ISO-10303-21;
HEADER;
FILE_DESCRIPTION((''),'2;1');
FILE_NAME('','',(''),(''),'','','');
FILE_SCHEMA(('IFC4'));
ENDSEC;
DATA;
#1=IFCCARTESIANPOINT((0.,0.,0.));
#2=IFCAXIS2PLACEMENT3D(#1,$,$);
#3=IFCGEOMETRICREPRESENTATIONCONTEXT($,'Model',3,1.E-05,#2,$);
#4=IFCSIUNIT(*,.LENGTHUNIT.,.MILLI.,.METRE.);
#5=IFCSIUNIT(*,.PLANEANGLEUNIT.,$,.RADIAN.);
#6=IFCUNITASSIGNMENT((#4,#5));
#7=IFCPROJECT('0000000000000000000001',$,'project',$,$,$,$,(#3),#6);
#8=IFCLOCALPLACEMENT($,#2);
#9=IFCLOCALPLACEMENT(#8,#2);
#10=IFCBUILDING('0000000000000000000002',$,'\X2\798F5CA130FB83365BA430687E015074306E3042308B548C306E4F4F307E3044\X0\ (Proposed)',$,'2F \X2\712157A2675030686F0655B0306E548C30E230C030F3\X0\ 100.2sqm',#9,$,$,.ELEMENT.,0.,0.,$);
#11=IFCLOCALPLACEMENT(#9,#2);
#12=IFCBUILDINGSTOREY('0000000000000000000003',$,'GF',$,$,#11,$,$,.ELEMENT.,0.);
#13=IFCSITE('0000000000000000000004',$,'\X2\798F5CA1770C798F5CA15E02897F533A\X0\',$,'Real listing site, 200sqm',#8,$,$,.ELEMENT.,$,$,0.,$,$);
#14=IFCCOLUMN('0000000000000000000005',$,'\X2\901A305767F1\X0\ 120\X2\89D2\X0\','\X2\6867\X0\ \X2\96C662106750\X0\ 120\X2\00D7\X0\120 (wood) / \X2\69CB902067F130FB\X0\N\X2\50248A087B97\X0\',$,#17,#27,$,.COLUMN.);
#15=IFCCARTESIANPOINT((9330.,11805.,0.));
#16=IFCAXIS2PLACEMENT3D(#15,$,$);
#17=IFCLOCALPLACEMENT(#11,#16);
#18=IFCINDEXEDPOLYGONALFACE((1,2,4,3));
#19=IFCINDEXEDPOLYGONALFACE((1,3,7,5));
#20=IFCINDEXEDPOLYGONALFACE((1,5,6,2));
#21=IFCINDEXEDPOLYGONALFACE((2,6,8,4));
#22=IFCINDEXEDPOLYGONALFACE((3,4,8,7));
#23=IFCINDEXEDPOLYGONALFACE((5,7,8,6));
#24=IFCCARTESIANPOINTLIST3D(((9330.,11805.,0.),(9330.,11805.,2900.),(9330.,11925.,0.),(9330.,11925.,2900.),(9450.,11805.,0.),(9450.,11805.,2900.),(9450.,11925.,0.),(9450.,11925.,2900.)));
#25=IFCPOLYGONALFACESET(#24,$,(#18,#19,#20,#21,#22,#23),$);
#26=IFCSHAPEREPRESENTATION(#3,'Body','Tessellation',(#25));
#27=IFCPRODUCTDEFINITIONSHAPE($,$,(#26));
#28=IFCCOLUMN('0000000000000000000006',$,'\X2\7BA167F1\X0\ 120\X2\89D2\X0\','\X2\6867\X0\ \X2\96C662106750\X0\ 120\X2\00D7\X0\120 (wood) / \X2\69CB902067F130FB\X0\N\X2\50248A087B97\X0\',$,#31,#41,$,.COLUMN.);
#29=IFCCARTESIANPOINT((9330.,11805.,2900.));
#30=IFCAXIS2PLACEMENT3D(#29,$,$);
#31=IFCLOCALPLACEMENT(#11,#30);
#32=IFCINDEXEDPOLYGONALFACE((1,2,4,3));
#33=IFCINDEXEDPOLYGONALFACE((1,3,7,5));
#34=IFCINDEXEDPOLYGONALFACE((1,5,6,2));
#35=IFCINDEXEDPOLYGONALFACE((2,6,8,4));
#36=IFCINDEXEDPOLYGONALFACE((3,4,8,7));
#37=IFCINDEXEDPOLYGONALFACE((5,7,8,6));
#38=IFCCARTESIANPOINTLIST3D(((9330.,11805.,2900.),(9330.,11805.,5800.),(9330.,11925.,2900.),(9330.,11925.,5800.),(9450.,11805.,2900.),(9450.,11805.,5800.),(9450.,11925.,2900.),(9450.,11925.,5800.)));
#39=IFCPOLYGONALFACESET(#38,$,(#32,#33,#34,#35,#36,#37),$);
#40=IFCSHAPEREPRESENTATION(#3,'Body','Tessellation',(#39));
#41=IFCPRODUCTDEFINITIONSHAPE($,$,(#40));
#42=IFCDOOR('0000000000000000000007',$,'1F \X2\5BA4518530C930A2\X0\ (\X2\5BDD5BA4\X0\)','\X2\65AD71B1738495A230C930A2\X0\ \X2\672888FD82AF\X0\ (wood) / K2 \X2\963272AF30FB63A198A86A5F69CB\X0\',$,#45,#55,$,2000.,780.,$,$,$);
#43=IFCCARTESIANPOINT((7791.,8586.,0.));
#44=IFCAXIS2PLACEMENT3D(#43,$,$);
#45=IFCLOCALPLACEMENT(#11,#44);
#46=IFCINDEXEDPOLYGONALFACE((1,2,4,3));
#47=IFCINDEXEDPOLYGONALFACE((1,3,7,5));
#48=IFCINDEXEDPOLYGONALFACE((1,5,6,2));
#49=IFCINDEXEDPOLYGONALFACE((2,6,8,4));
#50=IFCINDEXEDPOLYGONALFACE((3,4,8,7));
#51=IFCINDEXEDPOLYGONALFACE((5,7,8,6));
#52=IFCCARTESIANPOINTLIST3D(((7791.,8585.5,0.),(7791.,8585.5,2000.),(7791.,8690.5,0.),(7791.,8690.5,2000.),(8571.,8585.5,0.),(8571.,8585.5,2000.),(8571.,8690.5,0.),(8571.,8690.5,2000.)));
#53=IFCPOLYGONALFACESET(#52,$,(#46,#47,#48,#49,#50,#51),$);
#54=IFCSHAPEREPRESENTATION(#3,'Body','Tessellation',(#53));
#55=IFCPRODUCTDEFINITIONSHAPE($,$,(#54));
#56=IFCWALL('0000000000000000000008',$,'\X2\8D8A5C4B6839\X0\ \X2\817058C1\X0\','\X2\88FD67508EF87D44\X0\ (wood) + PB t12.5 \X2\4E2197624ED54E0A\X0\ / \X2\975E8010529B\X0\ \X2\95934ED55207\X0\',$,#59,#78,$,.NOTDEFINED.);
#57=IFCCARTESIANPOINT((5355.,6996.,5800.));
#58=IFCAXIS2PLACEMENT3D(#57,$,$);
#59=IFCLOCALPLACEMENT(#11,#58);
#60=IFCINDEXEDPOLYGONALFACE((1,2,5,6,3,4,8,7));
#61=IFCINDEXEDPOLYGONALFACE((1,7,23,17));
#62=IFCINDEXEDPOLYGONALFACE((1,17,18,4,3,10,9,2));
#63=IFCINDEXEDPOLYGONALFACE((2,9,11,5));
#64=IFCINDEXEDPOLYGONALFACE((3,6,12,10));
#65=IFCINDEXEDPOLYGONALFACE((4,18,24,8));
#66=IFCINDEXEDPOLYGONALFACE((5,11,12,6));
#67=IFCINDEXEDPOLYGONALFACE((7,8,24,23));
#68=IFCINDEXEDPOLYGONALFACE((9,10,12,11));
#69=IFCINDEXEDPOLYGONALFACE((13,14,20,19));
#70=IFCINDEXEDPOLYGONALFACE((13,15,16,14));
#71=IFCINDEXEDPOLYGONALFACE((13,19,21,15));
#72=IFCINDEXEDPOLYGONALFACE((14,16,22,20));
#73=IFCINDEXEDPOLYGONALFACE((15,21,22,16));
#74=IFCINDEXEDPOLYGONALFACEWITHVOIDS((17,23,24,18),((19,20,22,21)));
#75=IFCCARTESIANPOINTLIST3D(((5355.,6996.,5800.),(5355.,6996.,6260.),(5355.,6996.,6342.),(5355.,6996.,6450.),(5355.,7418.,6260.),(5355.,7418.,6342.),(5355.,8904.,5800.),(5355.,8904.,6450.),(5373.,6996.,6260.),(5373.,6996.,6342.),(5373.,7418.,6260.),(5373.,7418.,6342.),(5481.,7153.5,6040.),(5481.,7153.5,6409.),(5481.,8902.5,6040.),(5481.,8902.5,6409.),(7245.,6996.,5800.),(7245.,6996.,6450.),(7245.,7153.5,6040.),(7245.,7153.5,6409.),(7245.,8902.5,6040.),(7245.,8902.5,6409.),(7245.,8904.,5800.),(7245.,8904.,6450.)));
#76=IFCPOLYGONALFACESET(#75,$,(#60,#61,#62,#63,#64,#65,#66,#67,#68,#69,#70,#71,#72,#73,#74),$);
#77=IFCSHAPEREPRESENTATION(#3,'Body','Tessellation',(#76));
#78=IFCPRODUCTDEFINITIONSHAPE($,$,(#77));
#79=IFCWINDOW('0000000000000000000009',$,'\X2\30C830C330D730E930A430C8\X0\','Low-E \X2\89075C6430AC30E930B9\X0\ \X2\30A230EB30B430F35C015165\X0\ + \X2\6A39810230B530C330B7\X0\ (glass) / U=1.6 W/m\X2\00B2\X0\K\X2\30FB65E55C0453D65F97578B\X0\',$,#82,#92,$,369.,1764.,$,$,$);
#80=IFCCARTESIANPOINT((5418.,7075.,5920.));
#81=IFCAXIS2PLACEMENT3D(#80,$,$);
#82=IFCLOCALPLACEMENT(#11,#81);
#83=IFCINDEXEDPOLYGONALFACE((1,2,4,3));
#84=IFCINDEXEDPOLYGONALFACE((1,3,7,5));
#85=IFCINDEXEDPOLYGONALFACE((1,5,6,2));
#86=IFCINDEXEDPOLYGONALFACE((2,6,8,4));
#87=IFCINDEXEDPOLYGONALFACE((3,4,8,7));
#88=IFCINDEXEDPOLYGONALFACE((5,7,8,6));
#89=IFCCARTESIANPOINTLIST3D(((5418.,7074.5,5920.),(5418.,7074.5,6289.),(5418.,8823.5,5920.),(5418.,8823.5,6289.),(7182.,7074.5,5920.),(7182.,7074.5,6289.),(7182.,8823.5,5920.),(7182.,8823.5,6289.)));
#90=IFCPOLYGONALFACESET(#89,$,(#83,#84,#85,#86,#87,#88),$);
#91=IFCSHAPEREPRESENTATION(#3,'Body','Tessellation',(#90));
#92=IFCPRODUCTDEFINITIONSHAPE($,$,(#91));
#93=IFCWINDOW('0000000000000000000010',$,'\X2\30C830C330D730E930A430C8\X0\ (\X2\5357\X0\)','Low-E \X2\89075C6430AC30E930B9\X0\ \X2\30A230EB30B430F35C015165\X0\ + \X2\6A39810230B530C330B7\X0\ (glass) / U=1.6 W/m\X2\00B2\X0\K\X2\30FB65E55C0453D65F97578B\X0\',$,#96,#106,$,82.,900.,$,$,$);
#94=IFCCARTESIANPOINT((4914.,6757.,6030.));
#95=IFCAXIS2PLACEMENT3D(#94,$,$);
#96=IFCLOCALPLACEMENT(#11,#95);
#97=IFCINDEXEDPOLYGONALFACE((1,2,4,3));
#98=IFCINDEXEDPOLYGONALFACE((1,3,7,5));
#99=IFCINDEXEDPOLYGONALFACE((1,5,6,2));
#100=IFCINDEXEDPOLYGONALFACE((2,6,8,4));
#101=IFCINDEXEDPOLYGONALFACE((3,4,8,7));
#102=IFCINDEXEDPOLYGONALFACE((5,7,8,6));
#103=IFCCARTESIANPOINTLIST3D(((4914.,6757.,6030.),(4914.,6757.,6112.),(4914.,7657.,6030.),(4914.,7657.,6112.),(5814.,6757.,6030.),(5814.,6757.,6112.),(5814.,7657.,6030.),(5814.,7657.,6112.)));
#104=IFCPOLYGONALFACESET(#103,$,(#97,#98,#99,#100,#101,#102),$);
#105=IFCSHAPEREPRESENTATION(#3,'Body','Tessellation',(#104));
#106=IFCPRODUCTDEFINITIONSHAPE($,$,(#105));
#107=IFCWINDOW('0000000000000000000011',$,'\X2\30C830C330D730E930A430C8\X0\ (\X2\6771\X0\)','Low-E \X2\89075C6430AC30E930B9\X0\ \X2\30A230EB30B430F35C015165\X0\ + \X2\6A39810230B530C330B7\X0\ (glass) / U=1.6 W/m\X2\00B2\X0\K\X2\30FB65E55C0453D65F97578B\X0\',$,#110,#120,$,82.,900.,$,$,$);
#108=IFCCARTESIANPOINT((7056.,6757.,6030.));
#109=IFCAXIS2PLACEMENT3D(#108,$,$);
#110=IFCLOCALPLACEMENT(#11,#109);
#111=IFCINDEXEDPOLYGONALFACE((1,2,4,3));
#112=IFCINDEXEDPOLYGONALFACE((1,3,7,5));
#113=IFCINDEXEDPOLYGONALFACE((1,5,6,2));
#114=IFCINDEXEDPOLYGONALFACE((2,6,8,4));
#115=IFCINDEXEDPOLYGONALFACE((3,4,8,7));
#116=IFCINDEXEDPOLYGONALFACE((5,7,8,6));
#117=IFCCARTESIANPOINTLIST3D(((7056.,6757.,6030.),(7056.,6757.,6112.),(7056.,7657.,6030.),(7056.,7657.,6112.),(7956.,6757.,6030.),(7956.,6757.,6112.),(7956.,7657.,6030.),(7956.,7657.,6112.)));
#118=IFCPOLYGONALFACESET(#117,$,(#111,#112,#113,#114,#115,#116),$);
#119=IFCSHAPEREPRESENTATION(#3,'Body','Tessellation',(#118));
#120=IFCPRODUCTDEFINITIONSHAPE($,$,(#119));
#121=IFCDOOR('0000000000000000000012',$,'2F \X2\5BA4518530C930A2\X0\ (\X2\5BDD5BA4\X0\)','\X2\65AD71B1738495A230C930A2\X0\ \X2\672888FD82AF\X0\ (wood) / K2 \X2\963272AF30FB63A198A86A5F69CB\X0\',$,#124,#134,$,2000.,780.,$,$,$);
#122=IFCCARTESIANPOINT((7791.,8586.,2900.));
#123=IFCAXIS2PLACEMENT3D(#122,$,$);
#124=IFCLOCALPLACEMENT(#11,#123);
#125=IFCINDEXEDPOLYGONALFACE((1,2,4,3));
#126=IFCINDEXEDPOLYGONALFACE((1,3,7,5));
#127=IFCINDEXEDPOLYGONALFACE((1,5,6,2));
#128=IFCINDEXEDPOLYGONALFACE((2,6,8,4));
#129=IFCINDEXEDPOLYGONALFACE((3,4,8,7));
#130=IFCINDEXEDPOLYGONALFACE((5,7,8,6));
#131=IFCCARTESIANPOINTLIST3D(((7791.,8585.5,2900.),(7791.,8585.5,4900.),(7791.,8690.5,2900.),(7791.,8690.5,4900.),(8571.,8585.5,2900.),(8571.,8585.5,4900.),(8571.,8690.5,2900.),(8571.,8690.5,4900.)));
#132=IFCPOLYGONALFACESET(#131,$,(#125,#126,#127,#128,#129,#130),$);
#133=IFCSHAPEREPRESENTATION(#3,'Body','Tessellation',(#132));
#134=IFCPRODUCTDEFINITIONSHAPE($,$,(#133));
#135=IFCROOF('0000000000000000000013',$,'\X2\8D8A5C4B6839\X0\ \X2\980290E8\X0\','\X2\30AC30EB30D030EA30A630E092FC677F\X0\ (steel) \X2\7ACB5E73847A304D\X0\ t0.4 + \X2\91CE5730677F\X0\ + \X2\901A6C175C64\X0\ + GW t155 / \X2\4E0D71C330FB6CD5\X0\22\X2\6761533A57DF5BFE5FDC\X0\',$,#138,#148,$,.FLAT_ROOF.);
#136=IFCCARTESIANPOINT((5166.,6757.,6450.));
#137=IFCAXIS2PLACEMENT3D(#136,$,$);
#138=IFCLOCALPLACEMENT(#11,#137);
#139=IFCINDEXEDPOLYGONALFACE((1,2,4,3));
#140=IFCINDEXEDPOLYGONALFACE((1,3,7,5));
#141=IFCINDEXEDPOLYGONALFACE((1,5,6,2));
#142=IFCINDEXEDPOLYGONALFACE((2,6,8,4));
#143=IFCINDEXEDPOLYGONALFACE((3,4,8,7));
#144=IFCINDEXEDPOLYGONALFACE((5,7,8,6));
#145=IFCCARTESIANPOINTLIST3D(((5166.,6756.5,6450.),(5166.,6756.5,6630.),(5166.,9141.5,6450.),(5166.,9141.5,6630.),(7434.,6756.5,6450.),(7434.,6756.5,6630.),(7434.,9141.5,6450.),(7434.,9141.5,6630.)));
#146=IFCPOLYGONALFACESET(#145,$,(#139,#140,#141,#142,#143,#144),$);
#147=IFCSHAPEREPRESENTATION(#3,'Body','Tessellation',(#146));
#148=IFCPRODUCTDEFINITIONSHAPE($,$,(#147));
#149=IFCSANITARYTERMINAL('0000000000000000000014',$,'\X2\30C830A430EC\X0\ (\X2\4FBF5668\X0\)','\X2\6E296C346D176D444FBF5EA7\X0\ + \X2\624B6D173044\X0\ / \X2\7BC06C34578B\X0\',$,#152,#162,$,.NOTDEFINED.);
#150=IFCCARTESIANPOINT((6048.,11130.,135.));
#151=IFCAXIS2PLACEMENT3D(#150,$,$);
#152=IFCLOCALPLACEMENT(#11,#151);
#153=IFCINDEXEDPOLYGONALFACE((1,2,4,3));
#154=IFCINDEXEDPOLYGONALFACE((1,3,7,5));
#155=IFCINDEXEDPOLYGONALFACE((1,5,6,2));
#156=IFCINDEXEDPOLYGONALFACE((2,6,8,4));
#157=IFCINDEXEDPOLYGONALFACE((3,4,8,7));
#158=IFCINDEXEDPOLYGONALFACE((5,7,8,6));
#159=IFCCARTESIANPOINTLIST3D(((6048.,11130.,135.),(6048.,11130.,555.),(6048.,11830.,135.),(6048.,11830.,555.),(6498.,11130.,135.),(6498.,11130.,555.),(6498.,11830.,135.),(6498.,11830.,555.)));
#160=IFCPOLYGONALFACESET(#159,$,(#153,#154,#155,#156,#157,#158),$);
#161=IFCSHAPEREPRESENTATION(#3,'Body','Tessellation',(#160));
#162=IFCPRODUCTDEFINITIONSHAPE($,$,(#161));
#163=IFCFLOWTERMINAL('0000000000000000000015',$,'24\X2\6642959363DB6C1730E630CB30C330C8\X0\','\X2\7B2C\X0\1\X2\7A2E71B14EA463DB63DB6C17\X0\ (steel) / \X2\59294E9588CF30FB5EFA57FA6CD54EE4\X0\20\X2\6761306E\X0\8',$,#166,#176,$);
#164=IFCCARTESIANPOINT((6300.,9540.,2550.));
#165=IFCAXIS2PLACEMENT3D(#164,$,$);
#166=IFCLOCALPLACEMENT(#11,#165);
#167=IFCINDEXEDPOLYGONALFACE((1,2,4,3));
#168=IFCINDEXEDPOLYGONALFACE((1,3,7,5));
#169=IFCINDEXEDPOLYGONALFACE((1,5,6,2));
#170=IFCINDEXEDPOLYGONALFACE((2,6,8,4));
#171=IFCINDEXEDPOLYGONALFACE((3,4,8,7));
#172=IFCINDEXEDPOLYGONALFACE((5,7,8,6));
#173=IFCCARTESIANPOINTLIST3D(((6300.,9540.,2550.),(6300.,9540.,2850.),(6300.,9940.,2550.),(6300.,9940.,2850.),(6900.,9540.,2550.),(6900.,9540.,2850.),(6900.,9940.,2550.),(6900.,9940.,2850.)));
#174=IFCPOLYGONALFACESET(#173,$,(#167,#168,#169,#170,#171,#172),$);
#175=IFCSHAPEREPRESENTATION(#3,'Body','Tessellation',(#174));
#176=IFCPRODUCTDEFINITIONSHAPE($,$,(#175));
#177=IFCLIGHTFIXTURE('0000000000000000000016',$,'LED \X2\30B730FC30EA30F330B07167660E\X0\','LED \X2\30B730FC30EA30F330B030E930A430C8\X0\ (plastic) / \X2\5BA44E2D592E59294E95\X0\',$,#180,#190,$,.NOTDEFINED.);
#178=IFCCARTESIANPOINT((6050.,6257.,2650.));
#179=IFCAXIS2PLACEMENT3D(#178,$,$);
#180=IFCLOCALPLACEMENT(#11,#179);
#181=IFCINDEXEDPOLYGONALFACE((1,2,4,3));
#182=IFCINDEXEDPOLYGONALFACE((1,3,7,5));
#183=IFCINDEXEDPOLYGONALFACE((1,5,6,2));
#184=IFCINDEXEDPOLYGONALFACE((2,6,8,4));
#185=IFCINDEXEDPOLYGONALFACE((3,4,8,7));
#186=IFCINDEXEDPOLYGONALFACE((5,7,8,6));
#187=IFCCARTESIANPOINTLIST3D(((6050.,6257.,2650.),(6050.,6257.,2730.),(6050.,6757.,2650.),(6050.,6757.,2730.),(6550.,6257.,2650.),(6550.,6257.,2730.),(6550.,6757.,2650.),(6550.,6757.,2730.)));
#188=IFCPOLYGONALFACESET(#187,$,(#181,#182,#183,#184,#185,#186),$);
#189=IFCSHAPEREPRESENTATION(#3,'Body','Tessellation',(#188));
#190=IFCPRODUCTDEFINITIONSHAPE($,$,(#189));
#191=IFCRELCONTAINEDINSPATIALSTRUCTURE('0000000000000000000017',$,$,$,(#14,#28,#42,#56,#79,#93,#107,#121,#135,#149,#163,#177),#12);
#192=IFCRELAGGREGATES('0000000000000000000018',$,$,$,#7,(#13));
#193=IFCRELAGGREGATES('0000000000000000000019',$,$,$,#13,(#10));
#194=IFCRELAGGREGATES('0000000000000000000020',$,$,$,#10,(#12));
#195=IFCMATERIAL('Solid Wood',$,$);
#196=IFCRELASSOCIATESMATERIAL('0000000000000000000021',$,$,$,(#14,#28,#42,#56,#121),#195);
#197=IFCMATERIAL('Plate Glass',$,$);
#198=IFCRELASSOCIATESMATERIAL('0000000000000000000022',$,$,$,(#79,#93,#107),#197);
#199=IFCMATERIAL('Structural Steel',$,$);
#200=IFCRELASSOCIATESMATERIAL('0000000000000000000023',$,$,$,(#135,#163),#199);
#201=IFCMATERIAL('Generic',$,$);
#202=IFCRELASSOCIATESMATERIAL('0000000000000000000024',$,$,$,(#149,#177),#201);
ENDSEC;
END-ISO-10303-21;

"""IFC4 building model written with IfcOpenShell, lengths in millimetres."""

from ifc_helpers import new_model, si_unit, frame, frame_2d, origin, place, context, project, spatial, rectangle, extrude, material, element, fill, save


model = new_model("IFC4")

# Units and contexts
model_context = context("Model", 3, precision=1e-05, world=origin())
ifc_project = project(units=[si_unit("LENGTHUNIT", "METRE", prefix="MILLI"), si_unit("PLANEANGLEUNIT", "RADIAN")], contexts=[model_context])

# Site, building, storey
site_placement = place(None, origin())
site = spatial("IfcSite", under=ifc_project, at=site_placement, Name="福岡県福岡市西区", ObjectType="Real listing site, 200sqm", CompositionType="ELEMENT", RefElevation=0.0)
building_placement = place(site_placement, origin())
building = spatial("IfcBuilding", under=site, at=building_placement, Name="福岡・茶室と縁側のある和の住まい (Proposed)", ObjectType="2F 無垢材と漆喰の和モダン 100.2sqm", CompositionType="ELEMENT", ElevationOfRefHeight=0.0, ElevationOfTerrain=0.0)
storey_placement = place(building_placement, origin())
storey = spatial("IfcBuildingStorey", under=building, at=storey_placement, Name="GF", CompositionType="ELEMENT", Elevation=0.0)

# Columns
ifc_material_1 = material(Name="Solid Wood")
column_1_placement = place(storey_placement, frame((9330.0, 11805.0, 0.0)))
element("IfcColumn", 1, at=column_1_placement, inside=storey, material=ifc_material_1, Name="通し柱 120角", Description="桧 集成材 120×120 (wood) / 構造柱・N値計算", PredefinedType="COLUMN", context=model_context, shape_type="SweptSolid", body=[
    extrude(rectangle(XDim=120.0, YDim=120.0, at=frame_2d((60.0, 60.0))), frame((9330.0, 11805.0, 0.0)), (0.0, 0.0, 1.0), 2900.0),
])
column_2_placement = place(storey_placement, frame((9330.0, 11805.0, 2900.0)))
element("IfcColumn", 2, at=column_2_placement, inside=storey, material=ifc_material_1, Name="管柱 120角", Description="桧 集成材 120×120 (wood) / 構造柱・N値計算", PredefinedType="COLUMN", context=model_context, shape_type="SweptSolid", body=[
    extrude(rectangle(XDim=120.0, YDim=120.0, at=frame_2d((60.0, 60.0))), frame((9330.0, 11805.0, 2900.0)), (0.0, 0.0, 1.0), 2900.0),
])

# Door
door_1_placement = place(storey_placement, frame((7791.0, 8586.0, 0.0)))
element("IfcDoor", 3, at=door_1_placement, inside=storey, material=ifc_material_1, Name="1F 室内ドア (寝室)", Description="断熱玄関ドア 木製芯 (wood) / K2 防犯・採風機構", OverallHeight=2000.0, OverallWidth=780.0, context=model_context, shape_type="SweptSolid", body=[
    extrude(rectangle(XDim=780.0, YDim=105.0, at=frame_2d((390.0, 52.0))), frame((7791.0, 8586.0, 0.0)), (0.0, 0.0, 1.0), 2000.0),
])

# Wall, openings, windows
wall_1_placement = place(storey_placement, frame((5355.0, 6996.0, 5800.0)))
wall_1 = element("IfcWall", 4, at=wall_1_placement, inside=storey, material=ifc_material_1, Name="越屋根 腰壁", Description="製材軸組 (wood) + PB t12.5 両面仕上 / 非耐力 間仕切", PredefinedType="NOTDEFINED", context=model_context, shape_type="SweptSolid", body=[
    extrude(rectangle(XDim=1890.0, YDim=1908.0, at=frame_2d((945.0, 954.0))), frame((5355.0, 6996.0, 5800.0)), (0.0, 0.0, 1.0), 650.0),
])
opening_1_placement = place(storey_placement, frame((5418.0, 7075.0, 5920.0)))
opening_1 = element("IfcOpeningElement", 5, at=opening_1_placement, cuts=wall_1, PredefinedType="NOTDEFINED", context=model_context, shape_type="SweptSolid", body=[
    extrude(rectangle(XDim=1764.0, YDim=1749.0, at=frame_2d((882.0, 874.0))), frame((5418.0, 7075.0, 5920.0)), (0.0, 0.0, 1.0), 369.0),
])
opening_2_placement = place(storey_placement, frame((4914.0, 6757.0, 6030.0)))
opening_2 = element("IfcOpeningElement", 6, at=opening_2_placement, cuts=wall_1, PredefinedType="NOTDEFINED", context=model_context, shape_type="SweptSolid", body=[
    extrude(rectangle(XDim=900.0, YDim=900.0, at=frame_2d((450.0, 450.0))), frame((4914.0, 6757.0, 6030.0)), (0.0, 0.0, 1.0), 82.0),
])
opening_3_placement = place(storey_placement, frame((7056.0, 6757.0, 6030.0)))
opening_3 = element("IfcOpeningElement", 7, at=opening_3_placement, cuts=wall_1, PredefinedType="NOTDEFINED", context=model_context, shape_type="SweptSolid", body=[
    extrude(rectangle(XDim=900.0, YDim=900.0, at=frame_2d((450.0, 450.0))), frame((7056.0, 6757.0, 6030.0)), (0.0, 0.0, 1.0), 82.0),
])
ifc_material_2 = material(Name="Plate Glass")
window_1_placement = place(storey_placement, frame((5418.0, 7075.0, 5920.0)))
window_1 = element("IfcWindow", 8, at=window_1_placement, inside=storey, material=ifc_material_2, Name="トップライト", Description="Low-E 複層ガラス アルゴン封入 + 樹脂サッシ (glass) / U=1.6 W/m²K・日射取得型", OverallHeight=369.0, OverallWidth=1764.0, context=model_context, shape_type="SweptSolid", body=[
    extrude(rectangle(XDim=1764.0, YDim=1749.0, at=frame_2d((882.0, 874.0))), frame((5418.0, 7075.0, 5920.0)), (0.0, 0.0, 1.0), 369.0),
])
fill(opening_1, window_1)
window_2_placement = place(storey_placement, frame((4914.0, 6757.0, 6030.0)))
window_2 = element("IfcWindow", 9, at=window_2_placement, inside=storey, material=ifc_material_2, Name="トップライト (南)", Description="Low-E 複層ガラス アルゴン封入 + 樹脂サッシ (glass) / U=1.6 W/m²K・日射取得型", OverallHeight=82.0, OverallWidth=900.0, context=model_context, shape_type="SweptSolid", body=[
    extrude(rectangle(XDim=900.0, YDim=900.0, at=frame_2d((450.0, 450.0))), frame((4914.0, 6757.0, 6030.0)), (0.0, 0.0, 1.0), 82.0),
])
fill(opening_2, window_2)
window_3_placement = place(storey_placement, frame((7056.0, 6757.0, 6030.0)))
window_3 = element("IfcWindow", 10, at=window_3_placement, inside=storey, material=ifc_material_2, Name="トップライト (東)", Description="Low-E 複層ガラス アルゴン封入 + 樹脂サッシ (glass) / U=1.6 W/m²K・日射取得型", OverallHeight=82.0, OverallWidth=900.0, context=model_context, shape_type="SweptSolid", body=[
    extrude(rectangle(XDim=900.0, YDim=900.0, at=frame_2d((450.0, 450.0))), frame((7056.0, 6757.0, 6030.0)), (0.0, 0.0, 1.0), 82.0),
])
fill(opening_3, window_3)

# Door
door_2_placement = place(storey_placement, frame((7791.0, 8586.0, 2900.0)))
element("IfcDoor", 11, at=door_2_placement, inside=storey, material=ifc_material_1, Name="2F 室内ドア (寝室)", Description="断熱玄関ドア 木製芯 (wood) / K2 防犯・採風機構", OverallHeight=2000.0, OverallWidth=780.0, context=model_context, shape_type="SweptSolid", body=[
    extrude(rectangle(XDim=780.0, YDim=105.0, at=frame_2d((390.0, 52.0))), frame((7791.0, 8586.0, 2900.0)), (0.0, 0.0, 1.0), 2000.0),
])

# Roof
ifc_material_3 = material(Name="Structural Steel")
roof_placement = place(storey_placement, frame((5166.0, 6757.0, 6450.0)))
element("IfcRoof", 12, at=roof_placement, inside=storey, material=ifc_material_3, Name="越屋根 頂部", Description="ガルバリウム鋼板 (steel) 立平葺き t0.4 + 野地板 + 通気層 + GW t155 / 不燃・法22条区域対応", PredefinedType="FLAT_ROOF", context=model_context, shape_type="SweptSolid", body=[
    extrude(rectangle(XDim=2268.0, YDim=2385.0, at=frame_2d((1134.0, 1192.0))), frame((5166.0, 6757.0, 6450.0)), (0.0, 0.0, 1.0), 180.0),
])

# Sanitary terminal
ifc_material_4 = material(Name="Generic")
sanitary_terminal_placement = place(storey_placement, frame((6048.0, 11130.0, 135.0)))
element("IfcSanitaryTerminal", 13, at=sanitary_terminal_placement, inside=storey, material=ifc_material_4, Name="トイレ (便器)", Description="温水洗浄便座 + 手洗い / 節水型", PredefinedType="NOTDEFINED", context=model_context, shape_type="SweptSolid", body=[
    extrude(rectangle(XDim=450.0, YDim=700.0, at=frame_2d((225.0, 350.0))), frame((6048.0, 11130.0, 135.0)), (0.0, 0.0, 1.0), 420.0),
])

# Flow terminal
flow_terminal_placement = place(storey_placement, frame((6300.0, 9540.0, 2550.0)))
element("IfcFlowTerminal", 14, at=flow_terminal_placement, inside=storey, material=ifc_material_3, Name="24時間換気ユニット", Description="第1種熱交換換気 (steel) / 天井裏・建基法令20条の8", context=model_context, shape_type="SweptSolid", body=[
    extrude(rectangle(XDim=600.0, YDim=400.0, at=frame_2d((300.0, 200.0))), frame((6300.0, 9540.0, 2550.0)), (0.0, 0.0, 1.0), 300.0),
])

# Light fixture
light_fixture_1_placement = place(storey_placement, frame((6050.0, 6257.0, 2650.0)))
element("IfcLightFixture", 15, at=light_fixture_1_placement, inside=storey, material=ifc_material_4, Name="LED シーリング照明", Description="LED シーリングライト (plastic) / 室中央天井", PredefinedType="NOTDEFINED", context=model_context, shape_type="SweptSolid", body=[
    extrude(rectangle(XDim=500.0, YDim=500.0, at=frame_2d((250.0, 250.0))), frame((6050.0, 6257.0, 2650.0)), (0.0, 0.0, 1.0), 80.0),
])

save(model, "model.ifc")
